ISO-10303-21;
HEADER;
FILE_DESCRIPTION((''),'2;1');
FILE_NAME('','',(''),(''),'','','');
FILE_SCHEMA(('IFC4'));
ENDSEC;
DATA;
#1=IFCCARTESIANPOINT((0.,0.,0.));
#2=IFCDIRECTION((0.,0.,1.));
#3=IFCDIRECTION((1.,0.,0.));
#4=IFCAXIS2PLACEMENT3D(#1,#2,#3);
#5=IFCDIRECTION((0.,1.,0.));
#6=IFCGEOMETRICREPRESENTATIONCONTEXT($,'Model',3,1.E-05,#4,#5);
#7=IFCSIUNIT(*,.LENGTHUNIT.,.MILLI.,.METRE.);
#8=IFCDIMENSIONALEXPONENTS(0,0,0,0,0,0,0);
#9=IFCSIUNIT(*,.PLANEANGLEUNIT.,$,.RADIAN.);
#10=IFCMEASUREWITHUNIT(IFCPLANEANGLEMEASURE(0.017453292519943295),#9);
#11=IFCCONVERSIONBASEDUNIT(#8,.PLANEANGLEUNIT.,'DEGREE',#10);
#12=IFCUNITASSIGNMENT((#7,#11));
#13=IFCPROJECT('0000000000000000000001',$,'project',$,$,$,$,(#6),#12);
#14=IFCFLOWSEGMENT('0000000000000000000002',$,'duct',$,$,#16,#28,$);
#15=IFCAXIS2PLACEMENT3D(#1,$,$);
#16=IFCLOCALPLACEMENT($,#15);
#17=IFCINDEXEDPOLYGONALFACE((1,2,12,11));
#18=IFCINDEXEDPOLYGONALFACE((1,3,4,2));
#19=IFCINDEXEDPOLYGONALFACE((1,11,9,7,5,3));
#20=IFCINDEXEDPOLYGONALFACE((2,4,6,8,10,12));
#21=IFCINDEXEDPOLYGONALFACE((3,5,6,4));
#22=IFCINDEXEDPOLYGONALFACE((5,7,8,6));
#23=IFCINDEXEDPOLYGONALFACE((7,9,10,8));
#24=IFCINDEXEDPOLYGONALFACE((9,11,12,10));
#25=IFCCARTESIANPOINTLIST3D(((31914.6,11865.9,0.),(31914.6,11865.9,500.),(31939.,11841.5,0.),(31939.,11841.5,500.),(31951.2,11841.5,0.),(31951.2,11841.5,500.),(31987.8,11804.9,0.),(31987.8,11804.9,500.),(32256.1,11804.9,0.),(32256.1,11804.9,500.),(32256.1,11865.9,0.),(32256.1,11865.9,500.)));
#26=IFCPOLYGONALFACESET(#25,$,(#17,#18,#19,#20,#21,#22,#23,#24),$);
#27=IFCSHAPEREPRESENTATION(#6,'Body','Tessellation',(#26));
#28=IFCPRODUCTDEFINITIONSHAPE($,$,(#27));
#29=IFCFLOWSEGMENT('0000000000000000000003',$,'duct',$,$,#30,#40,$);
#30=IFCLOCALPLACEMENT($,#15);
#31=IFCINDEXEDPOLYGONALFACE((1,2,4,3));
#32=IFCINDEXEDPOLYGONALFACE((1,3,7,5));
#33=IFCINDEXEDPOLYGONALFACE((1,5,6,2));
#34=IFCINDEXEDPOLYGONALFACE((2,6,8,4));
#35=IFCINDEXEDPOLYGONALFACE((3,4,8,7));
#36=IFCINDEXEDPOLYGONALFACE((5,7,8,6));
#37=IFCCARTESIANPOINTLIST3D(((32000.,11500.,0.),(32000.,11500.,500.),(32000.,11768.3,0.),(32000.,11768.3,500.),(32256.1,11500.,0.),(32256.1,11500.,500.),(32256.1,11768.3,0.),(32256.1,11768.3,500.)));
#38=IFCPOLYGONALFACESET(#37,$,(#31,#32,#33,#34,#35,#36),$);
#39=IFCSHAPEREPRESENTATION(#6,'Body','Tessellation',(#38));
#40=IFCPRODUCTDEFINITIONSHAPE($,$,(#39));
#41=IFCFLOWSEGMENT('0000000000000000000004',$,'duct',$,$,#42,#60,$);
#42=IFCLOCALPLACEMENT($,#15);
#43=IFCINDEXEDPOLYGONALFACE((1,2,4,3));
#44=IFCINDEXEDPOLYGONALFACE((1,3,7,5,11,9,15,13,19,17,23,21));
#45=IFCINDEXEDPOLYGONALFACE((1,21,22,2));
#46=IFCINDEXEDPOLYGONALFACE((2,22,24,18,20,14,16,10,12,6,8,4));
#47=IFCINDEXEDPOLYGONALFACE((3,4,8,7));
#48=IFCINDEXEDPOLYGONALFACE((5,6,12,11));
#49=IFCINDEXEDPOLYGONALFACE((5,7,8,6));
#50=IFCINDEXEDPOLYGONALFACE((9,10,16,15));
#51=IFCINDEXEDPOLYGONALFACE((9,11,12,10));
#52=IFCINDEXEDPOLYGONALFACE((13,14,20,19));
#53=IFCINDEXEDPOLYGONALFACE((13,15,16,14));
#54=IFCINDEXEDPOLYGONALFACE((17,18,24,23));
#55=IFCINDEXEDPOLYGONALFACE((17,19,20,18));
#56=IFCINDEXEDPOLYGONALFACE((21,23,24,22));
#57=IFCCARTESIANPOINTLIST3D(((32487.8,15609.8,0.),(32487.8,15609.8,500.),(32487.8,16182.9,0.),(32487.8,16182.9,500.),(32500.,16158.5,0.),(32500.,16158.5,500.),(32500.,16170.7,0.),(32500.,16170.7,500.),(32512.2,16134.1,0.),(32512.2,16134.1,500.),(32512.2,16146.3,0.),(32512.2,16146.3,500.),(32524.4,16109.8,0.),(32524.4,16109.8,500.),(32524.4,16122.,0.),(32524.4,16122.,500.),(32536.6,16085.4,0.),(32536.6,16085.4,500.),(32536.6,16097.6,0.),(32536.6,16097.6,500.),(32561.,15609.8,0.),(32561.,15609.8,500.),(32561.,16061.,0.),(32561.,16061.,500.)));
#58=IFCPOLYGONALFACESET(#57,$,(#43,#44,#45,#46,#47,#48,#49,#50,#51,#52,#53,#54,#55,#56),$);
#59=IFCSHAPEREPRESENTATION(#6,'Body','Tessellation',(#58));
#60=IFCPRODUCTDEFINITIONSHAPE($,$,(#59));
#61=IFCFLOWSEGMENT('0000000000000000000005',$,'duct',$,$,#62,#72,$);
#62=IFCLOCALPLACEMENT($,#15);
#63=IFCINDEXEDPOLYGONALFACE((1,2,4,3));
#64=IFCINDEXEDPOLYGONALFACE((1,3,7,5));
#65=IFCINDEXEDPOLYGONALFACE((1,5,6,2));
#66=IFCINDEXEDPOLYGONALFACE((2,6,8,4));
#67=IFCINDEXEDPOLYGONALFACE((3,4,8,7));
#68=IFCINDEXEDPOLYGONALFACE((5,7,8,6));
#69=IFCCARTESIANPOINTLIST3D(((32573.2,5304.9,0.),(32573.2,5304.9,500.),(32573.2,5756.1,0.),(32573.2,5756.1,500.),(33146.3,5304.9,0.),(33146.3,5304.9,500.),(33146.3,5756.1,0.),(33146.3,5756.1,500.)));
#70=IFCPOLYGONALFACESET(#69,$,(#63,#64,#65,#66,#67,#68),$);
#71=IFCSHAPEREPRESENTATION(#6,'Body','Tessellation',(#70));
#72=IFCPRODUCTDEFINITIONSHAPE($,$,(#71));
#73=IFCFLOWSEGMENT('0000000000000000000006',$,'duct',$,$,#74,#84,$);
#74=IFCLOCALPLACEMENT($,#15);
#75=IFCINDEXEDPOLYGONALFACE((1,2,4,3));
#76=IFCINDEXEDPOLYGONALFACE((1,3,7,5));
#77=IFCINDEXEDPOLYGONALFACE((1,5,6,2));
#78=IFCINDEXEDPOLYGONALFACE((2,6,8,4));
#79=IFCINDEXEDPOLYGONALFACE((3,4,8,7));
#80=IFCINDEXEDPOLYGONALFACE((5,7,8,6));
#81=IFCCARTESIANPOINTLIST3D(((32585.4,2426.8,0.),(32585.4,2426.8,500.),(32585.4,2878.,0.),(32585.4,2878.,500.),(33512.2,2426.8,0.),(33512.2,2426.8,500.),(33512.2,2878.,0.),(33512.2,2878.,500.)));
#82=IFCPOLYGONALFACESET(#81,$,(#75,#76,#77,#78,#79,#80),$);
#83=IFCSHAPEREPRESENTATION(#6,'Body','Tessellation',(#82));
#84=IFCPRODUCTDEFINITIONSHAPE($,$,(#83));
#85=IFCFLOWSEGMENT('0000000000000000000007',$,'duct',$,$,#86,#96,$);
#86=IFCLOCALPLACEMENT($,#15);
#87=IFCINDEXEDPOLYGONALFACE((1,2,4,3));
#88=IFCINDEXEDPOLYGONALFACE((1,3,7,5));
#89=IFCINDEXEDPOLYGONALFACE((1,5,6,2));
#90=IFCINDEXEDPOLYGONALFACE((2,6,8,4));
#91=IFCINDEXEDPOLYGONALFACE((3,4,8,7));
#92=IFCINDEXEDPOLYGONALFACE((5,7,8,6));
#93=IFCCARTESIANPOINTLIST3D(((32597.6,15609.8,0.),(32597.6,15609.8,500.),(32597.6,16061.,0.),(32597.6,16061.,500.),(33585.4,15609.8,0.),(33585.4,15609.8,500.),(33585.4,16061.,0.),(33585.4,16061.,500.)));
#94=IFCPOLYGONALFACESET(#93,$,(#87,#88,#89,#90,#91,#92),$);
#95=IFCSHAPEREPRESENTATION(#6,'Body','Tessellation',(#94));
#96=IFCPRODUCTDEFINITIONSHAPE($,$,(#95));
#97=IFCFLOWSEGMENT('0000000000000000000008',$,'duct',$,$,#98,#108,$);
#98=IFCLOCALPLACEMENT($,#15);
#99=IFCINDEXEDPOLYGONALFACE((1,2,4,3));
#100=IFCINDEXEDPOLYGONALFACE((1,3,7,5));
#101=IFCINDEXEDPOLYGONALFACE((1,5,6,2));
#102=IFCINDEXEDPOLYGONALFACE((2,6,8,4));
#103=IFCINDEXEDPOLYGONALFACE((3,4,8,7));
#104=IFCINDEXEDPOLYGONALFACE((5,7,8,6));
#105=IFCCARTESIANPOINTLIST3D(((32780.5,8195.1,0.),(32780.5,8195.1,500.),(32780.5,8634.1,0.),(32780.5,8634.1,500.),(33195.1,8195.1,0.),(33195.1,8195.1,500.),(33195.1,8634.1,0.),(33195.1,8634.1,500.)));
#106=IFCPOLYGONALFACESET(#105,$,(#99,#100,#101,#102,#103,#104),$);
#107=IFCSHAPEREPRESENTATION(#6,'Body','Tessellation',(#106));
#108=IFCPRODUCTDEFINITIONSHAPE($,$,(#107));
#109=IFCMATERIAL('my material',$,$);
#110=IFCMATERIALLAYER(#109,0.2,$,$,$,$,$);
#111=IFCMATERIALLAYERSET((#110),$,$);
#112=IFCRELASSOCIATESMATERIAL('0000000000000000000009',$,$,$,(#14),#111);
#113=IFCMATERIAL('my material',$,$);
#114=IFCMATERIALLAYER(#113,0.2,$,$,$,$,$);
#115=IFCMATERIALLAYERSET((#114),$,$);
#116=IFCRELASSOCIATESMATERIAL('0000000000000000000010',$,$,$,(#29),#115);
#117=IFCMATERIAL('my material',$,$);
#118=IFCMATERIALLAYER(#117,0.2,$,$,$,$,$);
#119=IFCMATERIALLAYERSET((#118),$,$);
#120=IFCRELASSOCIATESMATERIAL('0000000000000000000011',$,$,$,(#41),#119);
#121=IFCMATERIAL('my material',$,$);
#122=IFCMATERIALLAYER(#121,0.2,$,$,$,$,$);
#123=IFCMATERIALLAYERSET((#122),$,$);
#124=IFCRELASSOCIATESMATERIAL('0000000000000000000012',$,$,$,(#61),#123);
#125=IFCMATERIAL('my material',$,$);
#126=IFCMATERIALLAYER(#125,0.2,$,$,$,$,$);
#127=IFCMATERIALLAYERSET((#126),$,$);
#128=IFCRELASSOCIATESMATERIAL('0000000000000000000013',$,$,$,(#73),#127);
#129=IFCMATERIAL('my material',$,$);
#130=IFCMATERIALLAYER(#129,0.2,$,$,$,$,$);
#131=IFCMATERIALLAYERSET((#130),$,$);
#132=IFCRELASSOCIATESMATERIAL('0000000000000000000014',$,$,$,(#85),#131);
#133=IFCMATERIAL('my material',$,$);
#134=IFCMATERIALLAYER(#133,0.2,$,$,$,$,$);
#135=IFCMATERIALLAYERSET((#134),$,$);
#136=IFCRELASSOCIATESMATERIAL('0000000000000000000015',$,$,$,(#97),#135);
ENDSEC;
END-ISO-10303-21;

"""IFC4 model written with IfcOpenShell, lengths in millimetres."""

from ifc_helpers import new_model, entity, si_unit, converted_unit, direction, origin_with_axes, place, context, project, polyline, outline, extrude, material, layer, layer_set, layer_usage, element, save


model = new_model("IFC4")

# Units and contexts
model_context = context("Model", 3, precision=1e-05, world=origin_with_axes(), true_north=direction((0.0, 1.0, 0.0)))
ifc_project = project(units=[si_unit("LENGTHUNIT", "METRE", prefix="MILLI"), converted_unit("PLANEANGLEUNIT", "DEGREE", entity("IfcPlaneAngleMeasure", 0.017453292519943295), si_unit("PLANEANGLEUNIT", "RADIAN"), dimensions=[0, 0, 0, 0, 0, 0, 0])], contexts=[model_context])

# Flow segments
ifc_material_1 = material(Name="my material")
ifc_layer_1 = layer(ifc_material_1, 0.2)
ifc_layer_set_1 = layer_set([ifc_layer_1])
ifc_layer_usage_1 = layer_usage(ifc_layer_set_1, "AXIS2", "POSITIVE", -0.1)
flow_segment_1_placement = place(None, origin_with_axes())
element("IfcFlowSegment", 1, at=flow_segment_1_placement, material=ifc_layer_usage_1, Name="duct", context=model_context, shape_type="SweptSolid", body=[
    extrude(outline(polyline([(31914.6, 11865.9), (31939.0, 11841.5), (31951.2, 11841.5), (31987.8, 11804.9), (32256.1, 11804.9), (32256.1, 11865.9), (31914.6, 11865.9)])), origin_with_axes(), (0.0, 0.0, 1.0), 500.0),
])
ifc_material_2 = material(Name="my material")
ifc_layer_2 = layer(ifc_material_2, 0.2)
ifc_layer_set_2 = layer_set([ifc_layer_2])
ifc_layer_usage_2 = layer_usage(ifc_layer_set_2, "AXIS2", "POSITIVE", -0.1)
flow_segment_2_placement = place(None, origin_with_axes())
element("IfcFlowSegment", 2, at=flow_segment_2_placement, material=ifc_layer_usage_2, Name="duct", context=model_context, shape_type="SweptSolid", body=[
    extrude(outline(polyline([(32000.0, 11500.0), (32256.1, 11500.0), (32256.1, 11768.3), (32000.0, 11768.3), (32000.0, 11500.0)])), origin_with_axes(), (0.0, 0.0, 1.0), 500.0),
])
ifc_material_3 = material(Name="my material")
ifc_layer_3 = layer(ifc_material_3, 0.2)
ifc_layer_set_3 = layer_set([ifc_layer_3])
ifc_layer_usage_3 = layer_usage(ifc_layer_set_3, "AXIS2", "POSITIVE", -0.1)
flow_segment_3_placement = place(None, origin_with_axes())
element("IfcFlowSegment", 3, at=flow_segment_3_placement, material=ifc_layer_usage_3, Name="duct", context=model_context, shape_type="SweptSolid", body=[
    extrude(outline(polyline([(32487.8, 15609.8), (32561.0, 15609.8), (32561.0, 16061.0), (32536.6, 16085.4), (32536.6, 16097.6), (32524.4, 16109.8), (32524.4, 16122.0), (32512.2, 16134.1), (32512.2, 16146.3), (32500.0, 16158.5), (32500.0, 16170.7), (32487.8, 16182.9), (32487.8, 16195.1), (32487.8, 15609.8)])), origin_with_axes(), (0.0, 0.0, 1.0), 500.0),
])
ifc_material_4 = material(Name="my material")
ifc_layer_4 = layer(ifc_material_4, 0.2)
ifc_layer_set_4 = layer_set([ifc_layer_4])
ifc_layer_usage_4 = layer_usage(ifc_layer_set_4, "AXIS2", "POSITIVE", -0.1)
flow_segment_4_placement = place(None, origin_with_axes())
element("IfcFlowSegment", 4, at=flow_segment_4_placement, material=ifc_layer_usage_4, Name="duct", context=model_context, shape_type="SweptSolid", body=[
    extrude(outline(polyline([(32573.2, 5304.9), (33146.3, 5304.9), (33146.3, 5756.1), (32573.2, 5756.1), (32573.2, 5304.9)])), origin_with_axes(), (0.0, 0.0, 1.0), 500.0),
])
ifc_material_5 = material(Name="my material")
ifc_layer_5 = layer(ifc_material_5, 0.2)
ifc_layer_set_5 = layer_set([ifc_layer_5])
ifc_layer_usage_5 = layer_usage(ifc_layer_set_5, "AXIS2", "POSITIVE", -0.1)
flow_segment_5_placement = place(None, origin_with_axes())
element("IfcFlowSegment", 5, at=flow_segment_5_placement, material=ifc_layer_usage_5, Name="duct", context=model_context, shape_type="SweptSolid", body=[
    extrude(outline(polyline([(32585.4, 2426.8), (33512.2, 2426.8), (33512.2, 2878.0), (32585.4, 2878.0), (32585.4, 2426.8)])), origin_with_axes(), (0.0, 0.0, 1.0), 500.0),
])
ifc_material_6 = material(Name="my material")
ifc_layer_6 = layer(ifc_material_6, 0.2)
ifc_layer_set_6 = layer_set([ifc_layer_6])
ifc_layer_usage_6 = layer_usage(ifc_layer_set_6, "AXIS2", "POSITIVE", -0.1)
flow_segment_6_placement = place(None, origin_with_axes())
element("IfcFlowSegment", 6, at=flow_segment_6_placement, material=ifc_layer_usage_6, Name="duct", context=model_context, shape_type="SweptSolid", body=[
    extrude(outline(polyline([(32597.6, 15609.8), (33585.4, 15609.8), (33585.4, 16061.0), (32597.6, 16061.0), (32597.6, 15609.8)])), origin_with_axes(), (0.0, 0.0, 1.0), 500.0),
])
ifc_material_7 = material(Name="my material")
ifc_layer_7 = layer(ifc_material_7, 0.2)
ifc_layer_set_7 = layer_set([ifc_layer_7])
ifc_layer_usage_7 = layer_usage(ifc_layer_set_7, "AXIS2", "POSITIVE", -0.1)
flow_segment_7_placement = place(None, origin_with_axes())
element("IfcFlowSegment", 7, at=flow_segment_7_placement, material=ifc_layer_usage_7, Name="duct", context=model_context, shape_type="SweptSolid", body=[
    extrude(outline(polyline([(32780.5, 8195.1), (33195.1, 8195.1), (33195.1, 8634.1), (32780.5, 8634.1), (32780.5, 8195.1)])), origin_with_axes(), (0.0, 0.0, 1.0), 500.0),
])

save(model, "model.ifc")
